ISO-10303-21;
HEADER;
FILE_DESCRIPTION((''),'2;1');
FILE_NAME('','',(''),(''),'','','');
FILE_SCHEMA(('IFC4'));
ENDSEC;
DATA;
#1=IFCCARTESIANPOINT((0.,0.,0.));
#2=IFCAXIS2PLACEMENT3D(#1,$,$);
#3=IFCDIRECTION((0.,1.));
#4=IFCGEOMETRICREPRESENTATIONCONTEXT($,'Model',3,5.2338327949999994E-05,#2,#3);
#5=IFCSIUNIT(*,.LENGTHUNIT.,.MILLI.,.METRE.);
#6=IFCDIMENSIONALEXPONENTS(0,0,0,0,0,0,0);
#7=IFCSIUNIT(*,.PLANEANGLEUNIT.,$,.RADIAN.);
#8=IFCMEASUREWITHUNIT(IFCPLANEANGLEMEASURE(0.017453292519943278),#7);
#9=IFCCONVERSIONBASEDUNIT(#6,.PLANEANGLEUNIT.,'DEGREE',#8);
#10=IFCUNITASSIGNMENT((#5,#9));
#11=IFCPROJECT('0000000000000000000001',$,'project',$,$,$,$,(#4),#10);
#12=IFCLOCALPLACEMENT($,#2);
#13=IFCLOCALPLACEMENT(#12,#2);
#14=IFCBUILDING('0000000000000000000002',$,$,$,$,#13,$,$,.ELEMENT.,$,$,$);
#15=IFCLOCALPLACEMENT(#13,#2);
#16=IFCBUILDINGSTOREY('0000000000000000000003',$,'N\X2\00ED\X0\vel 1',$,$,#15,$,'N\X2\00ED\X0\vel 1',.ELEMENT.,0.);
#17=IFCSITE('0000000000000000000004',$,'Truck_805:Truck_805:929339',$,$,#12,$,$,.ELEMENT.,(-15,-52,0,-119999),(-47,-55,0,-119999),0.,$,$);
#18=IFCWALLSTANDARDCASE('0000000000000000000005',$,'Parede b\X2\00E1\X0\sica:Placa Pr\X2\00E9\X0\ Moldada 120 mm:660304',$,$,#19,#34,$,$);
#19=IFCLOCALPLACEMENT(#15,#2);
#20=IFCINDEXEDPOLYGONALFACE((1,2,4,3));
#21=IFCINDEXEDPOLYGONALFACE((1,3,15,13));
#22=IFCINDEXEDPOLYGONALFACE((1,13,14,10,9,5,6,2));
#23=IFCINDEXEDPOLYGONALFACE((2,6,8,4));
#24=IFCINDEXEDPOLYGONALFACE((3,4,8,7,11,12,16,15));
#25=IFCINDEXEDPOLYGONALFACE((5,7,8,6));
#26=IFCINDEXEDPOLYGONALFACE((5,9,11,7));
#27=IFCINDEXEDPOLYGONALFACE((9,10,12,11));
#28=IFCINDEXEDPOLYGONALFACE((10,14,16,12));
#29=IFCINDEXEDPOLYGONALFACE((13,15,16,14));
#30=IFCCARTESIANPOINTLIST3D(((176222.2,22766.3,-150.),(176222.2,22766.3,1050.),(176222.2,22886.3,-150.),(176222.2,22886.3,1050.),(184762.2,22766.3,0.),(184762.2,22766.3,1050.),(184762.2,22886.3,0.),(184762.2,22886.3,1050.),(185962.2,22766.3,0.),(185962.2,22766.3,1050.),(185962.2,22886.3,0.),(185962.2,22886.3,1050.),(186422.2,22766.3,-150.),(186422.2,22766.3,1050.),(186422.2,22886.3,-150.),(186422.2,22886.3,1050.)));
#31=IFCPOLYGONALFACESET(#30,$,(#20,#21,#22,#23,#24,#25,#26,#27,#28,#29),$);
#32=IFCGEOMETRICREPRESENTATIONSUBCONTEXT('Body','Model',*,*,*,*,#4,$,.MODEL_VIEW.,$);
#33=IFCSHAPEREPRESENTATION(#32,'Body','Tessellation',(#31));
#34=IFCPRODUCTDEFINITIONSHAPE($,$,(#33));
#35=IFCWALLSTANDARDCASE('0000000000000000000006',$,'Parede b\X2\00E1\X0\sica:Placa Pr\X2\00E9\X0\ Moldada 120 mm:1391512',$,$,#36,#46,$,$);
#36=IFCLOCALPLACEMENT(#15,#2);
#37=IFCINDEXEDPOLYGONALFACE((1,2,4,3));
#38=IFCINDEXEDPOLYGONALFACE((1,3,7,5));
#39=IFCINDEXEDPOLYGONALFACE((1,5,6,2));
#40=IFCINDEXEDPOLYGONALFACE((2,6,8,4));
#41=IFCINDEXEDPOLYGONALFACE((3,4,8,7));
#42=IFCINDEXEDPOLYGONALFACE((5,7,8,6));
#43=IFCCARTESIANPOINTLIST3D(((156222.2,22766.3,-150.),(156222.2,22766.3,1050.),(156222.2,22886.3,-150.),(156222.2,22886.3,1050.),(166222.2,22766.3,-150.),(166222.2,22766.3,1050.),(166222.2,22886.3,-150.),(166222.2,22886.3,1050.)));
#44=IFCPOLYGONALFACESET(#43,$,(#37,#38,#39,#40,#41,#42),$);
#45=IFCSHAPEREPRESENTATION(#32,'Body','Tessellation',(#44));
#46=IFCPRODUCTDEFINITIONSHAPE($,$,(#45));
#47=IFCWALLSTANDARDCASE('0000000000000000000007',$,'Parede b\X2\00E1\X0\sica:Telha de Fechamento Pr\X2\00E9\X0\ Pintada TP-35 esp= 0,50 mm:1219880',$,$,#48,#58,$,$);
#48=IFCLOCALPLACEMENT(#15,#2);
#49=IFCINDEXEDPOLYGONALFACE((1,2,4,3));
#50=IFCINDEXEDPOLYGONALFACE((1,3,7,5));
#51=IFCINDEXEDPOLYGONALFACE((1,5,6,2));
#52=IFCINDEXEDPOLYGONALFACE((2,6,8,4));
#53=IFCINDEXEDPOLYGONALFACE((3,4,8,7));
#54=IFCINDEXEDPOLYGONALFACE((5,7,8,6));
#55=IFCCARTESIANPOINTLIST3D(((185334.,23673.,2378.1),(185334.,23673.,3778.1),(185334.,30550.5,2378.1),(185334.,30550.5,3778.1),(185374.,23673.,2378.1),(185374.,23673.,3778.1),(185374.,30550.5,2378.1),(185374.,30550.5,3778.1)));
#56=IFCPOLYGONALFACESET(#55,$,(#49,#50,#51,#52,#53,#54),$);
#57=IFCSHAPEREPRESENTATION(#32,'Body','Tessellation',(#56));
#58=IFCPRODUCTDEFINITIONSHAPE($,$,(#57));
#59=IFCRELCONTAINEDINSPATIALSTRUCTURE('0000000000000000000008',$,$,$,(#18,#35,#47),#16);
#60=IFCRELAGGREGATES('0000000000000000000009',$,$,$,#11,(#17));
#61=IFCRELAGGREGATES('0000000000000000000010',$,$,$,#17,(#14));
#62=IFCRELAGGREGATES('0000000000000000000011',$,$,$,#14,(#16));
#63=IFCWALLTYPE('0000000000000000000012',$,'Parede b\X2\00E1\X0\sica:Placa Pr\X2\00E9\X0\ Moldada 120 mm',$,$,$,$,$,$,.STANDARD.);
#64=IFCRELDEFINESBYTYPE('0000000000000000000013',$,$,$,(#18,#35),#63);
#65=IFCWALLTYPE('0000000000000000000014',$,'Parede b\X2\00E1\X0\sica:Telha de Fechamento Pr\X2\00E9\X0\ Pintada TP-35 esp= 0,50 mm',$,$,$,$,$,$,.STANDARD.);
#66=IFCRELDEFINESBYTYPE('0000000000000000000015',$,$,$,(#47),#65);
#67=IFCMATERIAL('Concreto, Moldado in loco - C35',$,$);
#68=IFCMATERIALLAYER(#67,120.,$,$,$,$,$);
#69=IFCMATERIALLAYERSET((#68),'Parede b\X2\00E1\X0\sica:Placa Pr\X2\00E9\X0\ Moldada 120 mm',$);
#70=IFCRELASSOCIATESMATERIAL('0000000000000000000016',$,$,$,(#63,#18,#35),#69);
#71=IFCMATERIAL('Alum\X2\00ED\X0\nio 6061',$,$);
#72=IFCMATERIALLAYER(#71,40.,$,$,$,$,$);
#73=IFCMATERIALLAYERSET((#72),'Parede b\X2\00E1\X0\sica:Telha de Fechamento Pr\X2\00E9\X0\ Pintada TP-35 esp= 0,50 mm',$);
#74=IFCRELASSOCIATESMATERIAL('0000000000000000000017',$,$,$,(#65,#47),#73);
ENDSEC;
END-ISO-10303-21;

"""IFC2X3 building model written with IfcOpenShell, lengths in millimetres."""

from ifc_helpers import new_model, entity, si_unit, converted_unit, direction, frame, frame_2d, origin, place, context, subcontext, project, spatial, rectangle, extrude, material, layer, layer_set, layer_usage, type_object, element, save


model = new_model("IFC2X3")

# Units and contexts
model_context = context("Model", 3, precision=5.2338327949999994e-05, world=origin(), true_north=direction((0.0, 1.0)))
body_context = subcontext(model_context, "Body", "Model", "MODEL_VIEW")
ifc_project = project(units=[si_unit("LENGTHUNIT", "METRE", prefix="MILLI"), converted_unit("PLANEANGLEUNIT", "DEGREE", entity("IfcPlaneAngleMeasure", 0.017453292519943278), si_unit("PLANEANGLEUNIT", "RADIAN"), dimensions=[0, 0, 0, 0, 0, 0, 0])], contexts=[model_context])

# Site, building, storey
site_placement = place(None, origin())
site = spatial("IfcSite", under=ifc_project, at=site_placement, Name="Truck_805:Truck_805:929339", CompositionType="ELEMENT", RefLatitude=(-15, -52, 0, -119999), RefLongitude=(-47, -55, 0, -119999), RefElevation=0.0)
building_placement = place(site_placement, origin())
building = spatial("IfcBuilding", under=site, at=building_placement, CompositionType="ELEMENT")
storey_placement = place(building_placement, origin())
storey = spatial("IfcBuildingStorey", under=building, at=storey_placement, Name="Nível 1", LongName="Nível 1", CompositionType="ELEMENT", Elevation=0.0)

# Shared definitions
ifc_material_1 = material(Name="Concreto, Moldado in loco - C35")
ifc_layer_1 = layer(ifc_material_1, 120.0)
ifc_layer_set_1 = layer_set([ifc_layer_1], Name="Parede básica:Placa Pré Moldada 120 mm")
wall_type_1 = type_object("IfcWallType", Name="Parede básica:Placa Pré Moldada 120 mm", PredefinedType="STANDARD", material=ifc_layer_set_1)

# Wall, opening
ifc_layer_usage_1 = layer_usage(ifc_layer_set_1, "AXIS2", "NEGATIVE", 60.0)
wall_1_placement = place(storey_placement, frame((176222.2, 22826.3, -150.0)))
wall_1 = element("IfcWallStandardCase", 1, at=wall_1_placement, inside=storey, type_object=wall_type_1, material=ifc_layer_usage_1, Name="Parede básica:Placa Pré Moldada 120 mm:660304", context=body_context, shape_type="SweptSolid", body=[
    extrude(rectangle(XDim=10200.0, YDim=120.0, at=frame_2d((5100.0, 0.0), x_axis=(-1.0, 0.0))), origin(), (0.0, 0.0, 1.0), 1200.0),
])
opening_placement = place(wall_1_placement, frame((8540.0, -60.0, 150.0)))
element("IfcOpeningElement", 2, at=opening_placement, cuts=wall_1, ObjectType="Opening", context=body_context, shape_type="SweptSolid", body=[
    extrude(rectangle(XDim=2110.0, YDim=1200.0, at=frame_2d((1055.0, 600.0), x_axis=(-1.0, 0.0))), frame((0.0, 0.0, 0.0), z_axis=(0.0, 1.0, 0.0), x_axis=(0.0, 0.0, 1.0)), (0.0, 0.0, 1.0), 120.0),
])

# Walls
ifc_layer_usage_2 = layer_usage(ifc_layer_set_1, "AXIS2", "POSITIVE", -60.0)
wall_2_placement = place(storey_placement, frame((166222.2, 22826.3, -150.0), z_axis=(0.0, 0.0, 1.0), x_axis=(-1.0, 0.0, 0.0)))
element("IfcWallStandardCase", 3, at=wall_2_placement, inside=storey, type_object=wall_type_1, material=ifc_layer_usage_2, Name="Parede básica:Placa Pré Moldada 120 mm:1391512", context=body_context, shape_type="SweptSolid", body=[
    extrude(rectangle(XDim=10000.0, YDim=120.0, at=frame_2d((5000.0, 0.0), x_axis=(-1.0, 0.0))), origin(), (0.0, 0.0, 1.0), 1200.0),
])
ifc_material_2 = material(Name="Alumínio 6061")
ifc_layer_2 = layer(ifc_material_2, 40.0)
ifc_layer_set_2 = layer_set([ifc_layer_2], Name="Parede básica:Telha de Fechamento Pré Pintada TP-35 esp= 0,50 mm")
ifc_layer_usage_3 = layer_usage(ifc_layer_set_2, "AXIS2", "NEGATIVE", 20.0)
wall_type_2 = type_object("IfcWallType", Name="Parede básica:Telha de Fechamento Pré Pintada TP-35 esp= 0,50 mm", PredefinedType="STANDARD", material=ifc_layer_set_2)
wall_3_placement = place(storey_placement, frame((185354.0, 23673.0, 2378.1), z_axis=(0.0, 0.0, 1.0), x_axis=(0.0, 1.0, 0.0)))
element("IfcWallStandardCase", 4, at=wall_3_placement, inside=storey, type_object=wall_type_2, material=ifc_layer_usage_3, Name="Parede básica:Telha de Fechamento Pré Pintada TP-35 esp= 0,50 mm:1219880", context=body_context, shape_type="SweptSolid", body=[
    extrude(rectangle(XDim=6877.4, YDim=40.0, at=frame_2d((3438.7, 0.0), x_axis=(-1.0, 0.0))), origin(), (0.0, 0.0, 1.0), 1400.0),
])

save(model, "model.ifc")
